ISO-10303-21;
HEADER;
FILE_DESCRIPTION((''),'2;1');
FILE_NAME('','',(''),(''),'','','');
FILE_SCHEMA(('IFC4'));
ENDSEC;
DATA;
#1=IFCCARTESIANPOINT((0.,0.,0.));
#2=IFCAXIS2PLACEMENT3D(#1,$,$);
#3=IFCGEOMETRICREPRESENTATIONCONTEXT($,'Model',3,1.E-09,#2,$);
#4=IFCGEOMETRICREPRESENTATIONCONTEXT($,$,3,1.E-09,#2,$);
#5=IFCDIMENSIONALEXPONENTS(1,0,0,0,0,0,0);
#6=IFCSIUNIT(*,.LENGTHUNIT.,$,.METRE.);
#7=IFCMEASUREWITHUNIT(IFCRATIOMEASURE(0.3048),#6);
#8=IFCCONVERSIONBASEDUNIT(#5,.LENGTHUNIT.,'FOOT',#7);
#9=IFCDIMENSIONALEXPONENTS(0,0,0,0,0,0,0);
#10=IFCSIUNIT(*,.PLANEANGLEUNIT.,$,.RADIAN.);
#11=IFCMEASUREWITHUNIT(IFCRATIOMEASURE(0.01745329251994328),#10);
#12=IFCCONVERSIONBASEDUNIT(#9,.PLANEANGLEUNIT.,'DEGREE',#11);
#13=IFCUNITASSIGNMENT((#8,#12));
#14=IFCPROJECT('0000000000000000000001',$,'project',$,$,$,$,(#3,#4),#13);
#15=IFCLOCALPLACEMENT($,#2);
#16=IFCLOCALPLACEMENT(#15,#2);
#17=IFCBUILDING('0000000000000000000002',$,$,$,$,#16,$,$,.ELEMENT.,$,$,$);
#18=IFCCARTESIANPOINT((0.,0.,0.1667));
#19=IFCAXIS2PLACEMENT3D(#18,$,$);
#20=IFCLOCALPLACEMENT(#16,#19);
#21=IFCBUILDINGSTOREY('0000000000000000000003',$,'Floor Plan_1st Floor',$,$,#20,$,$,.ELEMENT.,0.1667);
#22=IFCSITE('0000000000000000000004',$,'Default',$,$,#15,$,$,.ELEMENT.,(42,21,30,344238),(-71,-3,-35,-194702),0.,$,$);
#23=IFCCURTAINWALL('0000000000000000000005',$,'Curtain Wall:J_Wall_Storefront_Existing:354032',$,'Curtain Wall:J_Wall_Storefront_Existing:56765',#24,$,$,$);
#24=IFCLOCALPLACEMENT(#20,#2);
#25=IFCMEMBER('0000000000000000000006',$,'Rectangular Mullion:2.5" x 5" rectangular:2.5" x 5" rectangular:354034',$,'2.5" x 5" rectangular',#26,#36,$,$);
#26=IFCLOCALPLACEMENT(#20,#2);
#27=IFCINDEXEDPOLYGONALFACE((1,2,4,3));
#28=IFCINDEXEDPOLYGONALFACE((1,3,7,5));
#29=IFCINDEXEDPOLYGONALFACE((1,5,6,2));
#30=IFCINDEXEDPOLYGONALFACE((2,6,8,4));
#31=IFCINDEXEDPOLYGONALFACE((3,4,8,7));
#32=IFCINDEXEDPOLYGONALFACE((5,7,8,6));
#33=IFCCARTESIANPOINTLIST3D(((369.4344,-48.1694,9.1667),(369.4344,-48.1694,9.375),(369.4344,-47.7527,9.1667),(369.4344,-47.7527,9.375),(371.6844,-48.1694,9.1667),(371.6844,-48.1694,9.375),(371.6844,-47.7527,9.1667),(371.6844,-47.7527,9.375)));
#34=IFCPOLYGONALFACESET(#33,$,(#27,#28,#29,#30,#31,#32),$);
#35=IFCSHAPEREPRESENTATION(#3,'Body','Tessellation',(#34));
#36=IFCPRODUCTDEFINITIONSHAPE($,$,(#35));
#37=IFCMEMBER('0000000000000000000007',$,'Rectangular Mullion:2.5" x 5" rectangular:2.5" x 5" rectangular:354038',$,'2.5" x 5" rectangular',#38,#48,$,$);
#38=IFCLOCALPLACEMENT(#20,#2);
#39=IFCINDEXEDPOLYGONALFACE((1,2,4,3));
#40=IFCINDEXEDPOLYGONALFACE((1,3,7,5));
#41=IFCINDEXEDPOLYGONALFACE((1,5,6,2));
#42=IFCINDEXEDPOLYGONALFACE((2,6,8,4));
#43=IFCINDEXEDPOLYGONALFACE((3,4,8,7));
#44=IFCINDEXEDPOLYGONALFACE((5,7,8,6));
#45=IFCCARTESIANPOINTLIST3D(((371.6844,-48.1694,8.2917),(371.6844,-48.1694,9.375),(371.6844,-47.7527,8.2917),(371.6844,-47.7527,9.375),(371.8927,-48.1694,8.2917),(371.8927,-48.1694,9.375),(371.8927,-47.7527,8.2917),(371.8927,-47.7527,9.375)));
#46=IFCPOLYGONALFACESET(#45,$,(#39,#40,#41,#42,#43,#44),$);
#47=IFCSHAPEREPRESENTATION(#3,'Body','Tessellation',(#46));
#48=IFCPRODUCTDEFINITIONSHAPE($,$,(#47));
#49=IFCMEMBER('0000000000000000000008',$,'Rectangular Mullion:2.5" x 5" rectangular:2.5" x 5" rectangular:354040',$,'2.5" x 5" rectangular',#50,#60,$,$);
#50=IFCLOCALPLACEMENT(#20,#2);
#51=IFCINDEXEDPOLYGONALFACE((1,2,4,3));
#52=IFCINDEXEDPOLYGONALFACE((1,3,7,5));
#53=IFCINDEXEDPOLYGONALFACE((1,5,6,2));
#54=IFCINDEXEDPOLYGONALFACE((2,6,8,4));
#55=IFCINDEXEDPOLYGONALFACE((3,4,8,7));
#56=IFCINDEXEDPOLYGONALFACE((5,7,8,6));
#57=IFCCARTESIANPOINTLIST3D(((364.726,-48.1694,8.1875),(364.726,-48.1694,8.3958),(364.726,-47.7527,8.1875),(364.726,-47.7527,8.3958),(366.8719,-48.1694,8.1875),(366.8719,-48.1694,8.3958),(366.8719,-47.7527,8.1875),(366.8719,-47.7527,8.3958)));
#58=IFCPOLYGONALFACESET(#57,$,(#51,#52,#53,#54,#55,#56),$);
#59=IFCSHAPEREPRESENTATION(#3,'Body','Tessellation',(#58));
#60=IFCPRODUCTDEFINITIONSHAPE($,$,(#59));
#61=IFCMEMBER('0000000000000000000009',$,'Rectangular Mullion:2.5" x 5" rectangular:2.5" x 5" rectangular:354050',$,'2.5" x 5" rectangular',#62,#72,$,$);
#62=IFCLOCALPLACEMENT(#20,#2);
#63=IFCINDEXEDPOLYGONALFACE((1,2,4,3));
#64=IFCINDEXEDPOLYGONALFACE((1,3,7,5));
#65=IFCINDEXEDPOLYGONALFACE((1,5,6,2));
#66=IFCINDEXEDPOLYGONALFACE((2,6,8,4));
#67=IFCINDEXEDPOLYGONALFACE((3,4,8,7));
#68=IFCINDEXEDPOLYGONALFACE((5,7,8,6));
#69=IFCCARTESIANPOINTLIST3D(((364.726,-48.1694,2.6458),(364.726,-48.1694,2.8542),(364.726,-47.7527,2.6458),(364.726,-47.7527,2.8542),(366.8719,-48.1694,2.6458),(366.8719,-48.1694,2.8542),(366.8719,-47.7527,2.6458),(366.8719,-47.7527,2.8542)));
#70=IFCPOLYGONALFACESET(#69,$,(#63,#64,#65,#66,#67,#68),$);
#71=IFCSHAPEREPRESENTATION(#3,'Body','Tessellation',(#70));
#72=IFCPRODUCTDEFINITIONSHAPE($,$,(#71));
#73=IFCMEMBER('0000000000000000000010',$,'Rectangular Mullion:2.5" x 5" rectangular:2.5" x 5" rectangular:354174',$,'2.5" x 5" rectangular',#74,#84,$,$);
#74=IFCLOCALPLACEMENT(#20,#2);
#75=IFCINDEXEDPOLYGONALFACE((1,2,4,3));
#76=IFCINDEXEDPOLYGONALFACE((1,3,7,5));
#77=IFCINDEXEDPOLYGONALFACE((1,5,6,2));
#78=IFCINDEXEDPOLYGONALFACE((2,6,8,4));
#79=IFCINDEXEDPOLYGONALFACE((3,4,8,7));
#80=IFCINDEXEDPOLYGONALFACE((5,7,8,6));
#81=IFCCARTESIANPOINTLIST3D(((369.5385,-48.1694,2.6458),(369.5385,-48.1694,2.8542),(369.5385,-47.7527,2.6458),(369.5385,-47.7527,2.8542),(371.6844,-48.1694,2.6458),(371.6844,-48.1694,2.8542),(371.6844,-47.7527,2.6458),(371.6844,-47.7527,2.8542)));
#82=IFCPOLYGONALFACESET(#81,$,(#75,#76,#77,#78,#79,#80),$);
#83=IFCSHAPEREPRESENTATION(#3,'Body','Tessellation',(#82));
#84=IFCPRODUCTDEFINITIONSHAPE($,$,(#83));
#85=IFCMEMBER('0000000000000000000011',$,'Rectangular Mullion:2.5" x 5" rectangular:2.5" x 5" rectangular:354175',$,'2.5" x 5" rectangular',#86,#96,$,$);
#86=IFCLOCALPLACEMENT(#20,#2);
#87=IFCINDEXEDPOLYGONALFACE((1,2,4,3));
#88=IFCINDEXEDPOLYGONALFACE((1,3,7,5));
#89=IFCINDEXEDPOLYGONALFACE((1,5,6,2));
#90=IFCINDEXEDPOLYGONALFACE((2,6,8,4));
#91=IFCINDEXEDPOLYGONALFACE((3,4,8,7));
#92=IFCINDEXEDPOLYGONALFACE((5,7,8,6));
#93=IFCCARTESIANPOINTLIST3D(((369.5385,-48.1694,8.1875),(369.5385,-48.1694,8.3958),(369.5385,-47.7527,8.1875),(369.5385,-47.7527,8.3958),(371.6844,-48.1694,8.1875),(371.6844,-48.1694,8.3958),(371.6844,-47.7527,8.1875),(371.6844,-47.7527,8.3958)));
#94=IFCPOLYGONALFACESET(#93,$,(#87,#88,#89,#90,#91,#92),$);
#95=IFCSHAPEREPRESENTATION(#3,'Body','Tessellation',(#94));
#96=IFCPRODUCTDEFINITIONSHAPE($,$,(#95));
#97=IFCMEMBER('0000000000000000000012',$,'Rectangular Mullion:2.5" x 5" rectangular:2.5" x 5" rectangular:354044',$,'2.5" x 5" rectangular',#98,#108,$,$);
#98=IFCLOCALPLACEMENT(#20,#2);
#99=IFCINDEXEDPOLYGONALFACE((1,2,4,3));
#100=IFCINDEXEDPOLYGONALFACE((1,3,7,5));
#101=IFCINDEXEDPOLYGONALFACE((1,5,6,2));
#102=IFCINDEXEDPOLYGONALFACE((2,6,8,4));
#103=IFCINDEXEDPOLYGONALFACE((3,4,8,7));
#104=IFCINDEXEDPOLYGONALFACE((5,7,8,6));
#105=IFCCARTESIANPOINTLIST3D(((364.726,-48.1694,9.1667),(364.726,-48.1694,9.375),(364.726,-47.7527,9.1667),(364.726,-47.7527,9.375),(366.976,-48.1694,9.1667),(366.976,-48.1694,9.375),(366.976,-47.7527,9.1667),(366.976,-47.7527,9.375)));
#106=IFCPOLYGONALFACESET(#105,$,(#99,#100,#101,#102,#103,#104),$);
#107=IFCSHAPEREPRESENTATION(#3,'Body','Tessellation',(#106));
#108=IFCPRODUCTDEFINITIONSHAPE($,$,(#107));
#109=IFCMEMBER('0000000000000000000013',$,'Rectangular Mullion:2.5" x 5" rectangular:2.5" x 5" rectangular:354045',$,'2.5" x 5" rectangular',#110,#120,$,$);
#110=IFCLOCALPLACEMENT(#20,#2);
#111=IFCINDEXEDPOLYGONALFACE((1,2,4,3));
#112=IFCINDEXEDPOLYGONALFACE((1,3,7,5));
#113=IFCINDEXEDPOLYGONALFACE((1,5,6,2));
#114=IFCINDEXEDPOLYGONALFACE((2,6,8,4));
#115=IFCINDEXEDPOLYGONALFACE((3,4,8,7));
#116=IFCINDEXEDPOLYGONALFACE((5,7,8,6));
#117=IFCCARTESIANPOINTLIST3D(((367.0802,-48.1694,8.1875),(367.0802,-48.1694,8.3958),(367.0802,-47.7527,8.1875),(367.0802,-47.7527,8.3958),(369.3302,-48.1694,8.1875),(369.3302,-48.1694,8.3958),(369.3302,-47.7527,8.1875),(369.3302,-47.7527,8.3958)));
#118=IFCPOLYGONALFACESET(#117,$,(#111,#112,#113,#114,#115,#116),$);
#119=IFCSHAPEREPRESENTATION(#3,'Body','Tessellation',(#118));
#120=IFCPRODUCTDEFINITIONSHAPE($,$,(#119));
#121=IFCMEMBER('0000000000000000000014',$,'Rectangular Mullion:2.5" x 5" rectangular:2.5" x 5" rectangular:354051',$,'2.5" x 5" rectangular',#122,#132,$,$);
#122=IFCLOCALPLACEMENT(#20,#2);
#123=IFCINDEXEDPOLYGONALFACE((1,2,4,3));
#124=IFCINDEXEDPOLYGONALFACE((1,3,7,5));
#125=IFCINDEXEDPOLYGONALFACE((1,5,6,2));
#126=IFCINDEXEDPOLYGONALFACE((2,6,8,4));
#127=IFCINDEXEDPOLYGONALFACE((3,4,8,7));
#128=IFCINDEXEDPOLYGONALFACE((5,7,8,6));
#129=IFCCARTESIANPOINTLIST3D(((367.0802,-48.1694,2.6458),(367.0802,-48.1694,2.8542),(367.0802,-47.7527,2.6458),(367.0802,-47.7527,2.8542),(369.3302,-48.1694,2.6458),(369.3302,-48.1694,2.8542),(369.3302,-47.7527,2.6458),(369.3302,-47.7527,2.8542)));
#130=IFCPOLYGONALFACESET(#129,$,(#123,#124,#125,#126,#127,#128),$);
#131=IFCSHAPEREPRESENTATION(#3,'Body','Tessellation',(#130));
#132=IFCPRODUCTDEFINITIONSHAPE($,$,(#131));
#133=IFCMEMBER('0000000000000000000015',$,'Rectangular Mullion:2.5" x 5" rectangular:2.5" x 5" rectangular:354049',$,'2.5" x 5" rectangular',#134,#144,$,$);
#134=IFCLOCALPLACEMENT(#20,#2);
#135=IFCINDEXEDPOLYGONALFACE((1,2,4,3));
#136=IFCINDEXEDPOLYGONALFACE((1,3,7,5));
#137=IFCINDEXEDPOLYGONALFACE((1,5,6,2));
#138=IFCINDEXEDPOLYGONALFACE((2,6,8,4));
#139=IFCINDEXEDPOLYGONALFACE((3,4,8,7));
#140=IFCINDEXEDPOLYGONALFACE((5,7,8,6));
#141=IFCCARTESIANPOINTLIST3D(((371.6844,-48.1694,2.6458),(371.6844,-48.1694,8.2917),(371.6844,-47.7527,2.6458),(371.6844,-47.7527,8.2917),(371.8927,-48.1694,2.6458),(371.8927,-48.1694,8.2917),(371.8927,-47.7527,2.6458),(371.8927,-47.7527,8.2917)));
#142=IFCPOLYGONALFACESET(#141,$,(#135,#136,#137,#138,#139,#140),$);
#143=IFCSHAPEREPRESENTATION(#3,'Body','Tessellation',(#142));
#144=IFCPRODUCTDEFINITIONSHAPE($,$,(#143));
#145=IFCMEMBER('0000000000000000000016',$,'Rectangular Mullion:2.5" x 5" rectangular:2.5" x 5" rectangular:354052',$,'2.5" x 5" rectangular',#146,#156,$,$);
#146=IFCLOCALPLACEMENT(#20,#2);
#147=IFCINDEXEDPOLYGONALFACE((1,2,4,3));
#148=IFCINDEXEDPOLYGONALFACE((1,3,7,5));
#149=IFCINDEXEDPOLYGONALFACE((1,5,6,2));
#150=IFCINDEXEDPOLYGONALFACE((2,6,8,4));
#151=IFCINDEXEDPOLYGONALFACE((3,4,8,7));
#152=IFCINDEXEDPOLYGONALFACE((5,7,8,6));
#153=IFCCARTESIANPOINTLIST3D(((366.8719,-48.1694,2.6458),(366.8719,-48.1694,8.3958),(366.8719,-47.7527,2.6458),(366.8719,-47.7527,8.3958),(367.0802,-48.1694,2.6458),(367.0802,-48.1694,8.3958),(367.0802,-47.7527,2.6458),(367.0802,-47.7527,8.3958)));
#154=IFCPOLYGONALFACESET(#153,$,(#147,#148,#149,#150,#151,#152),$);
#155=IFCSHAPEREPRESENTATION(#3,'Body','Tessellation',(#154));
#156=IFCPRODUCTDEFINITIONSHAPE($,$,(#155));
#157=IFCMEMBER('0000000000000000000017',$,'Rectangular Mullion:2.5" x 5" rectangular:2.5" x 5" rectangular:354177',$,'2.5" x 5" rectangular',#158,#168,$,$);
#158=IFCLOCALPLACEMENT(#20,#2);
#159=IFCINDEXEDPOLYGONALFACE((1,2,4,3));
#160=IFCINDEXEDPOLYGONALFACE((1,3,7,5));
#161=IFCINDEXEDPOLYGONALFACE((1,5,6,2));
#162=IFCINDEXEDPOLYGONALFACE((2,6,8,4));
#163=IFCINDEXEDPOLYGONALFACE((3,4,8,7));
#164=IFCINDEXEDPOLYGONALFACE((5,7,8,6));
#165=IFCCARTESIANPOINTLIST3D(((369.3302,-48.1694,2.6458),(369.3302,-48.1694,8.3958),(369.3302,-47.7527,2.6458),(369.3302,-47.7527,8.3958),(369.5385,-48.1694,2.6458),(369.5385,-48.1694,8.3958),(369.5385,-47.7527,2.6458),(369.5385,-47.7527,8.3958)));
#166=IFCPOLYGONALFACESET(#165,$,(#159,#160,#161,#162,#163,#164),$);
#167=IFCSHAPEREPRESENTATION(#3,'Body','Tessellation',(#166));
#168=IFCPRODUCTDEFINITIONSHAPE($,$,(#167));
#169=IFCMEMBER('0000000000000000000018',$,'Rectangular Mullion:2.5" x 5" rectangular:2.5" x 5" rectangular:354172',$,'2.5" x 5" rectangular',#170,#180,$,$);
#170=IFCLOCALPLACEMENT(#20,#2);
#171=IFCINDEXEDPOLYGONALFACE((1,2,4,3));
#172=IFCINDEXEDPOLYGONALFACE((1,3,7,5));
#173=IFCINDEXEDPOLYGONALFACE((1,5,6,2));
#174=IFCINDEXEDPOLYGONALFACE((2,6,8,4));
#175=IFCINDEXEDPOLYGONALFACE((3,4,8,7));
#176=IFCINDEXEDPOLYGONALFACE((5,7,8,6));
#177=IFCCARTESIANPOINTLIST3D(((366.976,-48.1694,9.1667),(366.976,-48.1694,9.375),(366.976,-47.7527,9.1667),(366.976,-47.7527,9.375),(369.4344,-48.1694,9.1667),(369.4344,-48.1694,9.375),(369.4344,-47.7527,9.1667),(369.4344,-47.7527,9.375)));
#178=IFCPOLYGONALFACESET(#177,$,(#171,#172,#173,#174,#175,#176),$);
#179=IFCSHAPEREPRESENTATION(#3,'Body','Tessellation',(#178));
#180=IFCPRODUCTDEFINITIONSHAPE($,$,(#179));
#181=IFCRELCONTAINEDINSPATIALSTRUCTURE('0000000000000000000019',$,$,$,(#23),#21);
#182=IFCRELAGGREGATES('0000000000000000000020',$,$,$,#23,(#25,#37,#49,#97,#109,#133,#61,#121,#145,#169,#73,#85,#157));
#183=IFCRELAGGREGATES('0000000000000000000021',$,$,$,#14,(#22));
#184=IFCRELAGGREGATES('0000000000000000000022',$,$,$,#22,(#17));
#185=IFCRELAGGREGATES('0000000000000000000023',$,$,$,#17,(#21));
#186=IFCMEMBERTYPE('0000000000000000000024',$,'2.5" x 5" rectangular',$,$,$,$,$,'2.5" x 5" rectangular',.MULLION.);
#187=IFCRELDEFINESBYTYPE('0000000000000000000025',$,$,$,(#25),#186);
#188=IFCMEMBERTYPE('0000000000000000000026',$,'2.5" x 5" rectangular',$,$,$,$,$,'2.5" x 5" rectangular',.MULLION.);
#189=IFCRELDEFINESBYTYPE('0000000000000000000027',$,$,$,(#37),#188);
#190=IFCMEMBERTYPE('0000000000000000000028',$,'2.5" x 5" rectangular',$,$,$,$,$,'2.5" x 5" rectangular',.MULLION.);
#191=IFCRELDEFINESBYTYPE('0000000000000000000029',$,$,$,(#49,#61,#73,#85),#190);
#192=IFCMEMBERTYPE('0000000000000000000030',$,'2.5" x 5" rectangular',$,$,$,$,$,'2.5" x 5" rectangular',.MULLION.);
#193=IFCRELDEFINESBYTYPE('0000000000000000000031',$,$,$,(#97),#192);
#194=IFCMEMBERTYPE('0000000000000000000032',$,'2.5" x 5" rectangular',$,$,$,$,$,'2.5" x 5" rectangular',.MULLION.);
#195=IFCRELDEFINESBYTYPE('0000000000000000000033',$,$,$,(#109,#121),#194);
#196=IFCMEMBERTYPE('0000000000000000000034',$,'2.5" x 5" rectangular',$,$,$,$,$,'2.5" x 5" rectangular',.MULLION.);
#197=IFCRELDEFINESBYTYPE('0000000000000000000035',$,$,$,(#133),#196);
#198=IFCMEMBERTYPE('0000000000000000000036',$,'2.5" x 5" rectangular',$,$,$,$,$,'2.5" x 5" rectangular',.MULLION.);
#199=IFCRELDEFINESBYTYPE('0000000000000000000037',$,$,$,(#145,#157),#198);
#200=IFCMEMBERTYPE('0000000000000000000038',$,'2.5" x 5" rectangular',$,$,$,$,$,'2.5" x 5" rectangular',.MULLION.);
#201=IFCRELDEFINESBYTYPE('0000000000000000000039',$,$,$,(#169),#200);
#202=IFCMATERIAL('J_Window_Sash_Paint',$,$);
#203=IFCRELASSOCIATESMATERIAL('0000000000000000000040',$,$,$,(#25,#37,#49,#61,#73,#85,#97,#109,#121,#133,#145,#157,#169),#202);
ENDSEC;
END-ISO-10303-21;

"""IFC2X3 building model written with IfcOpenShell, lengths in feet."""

from ifc_helpers import new_model, entity, si_unit, converted_unit, frame, origin, origin_2d_with_axis, place, context, project, spatial, rectangle, extrude, source, transform, mapped, material, type_object, type_shapes, element, aggregate, save


model = new_model("IFC2X3")

# Units and contexts
model_context = context("Model", 3, precision=1e-09, world=origin())
context_of_model = context(None, 3, precision=1e-09, world=origin())
ifc_project = project(units=[converted_unit("LENGTHUNIT", "FOOT", entity("IfcRatioMeasure", 0.3048), si_unit("LENGTHUNIT", "METRE"), dimensions=[1, 0, 0, 0, 0, 0, 0]), converted_unit("PLANEANGLEUNIT", "DEGREE", entity("IfcRatioMeasure", 0.01745329251994328), si_unit("PLANEANGLEUNIT", "RADIAN"), dimensions=[0, 0, 0, 0, 0, 0, 0])], contexts=[model_context, context_of_model])

# Site, building, storey
site_placement = place(None, origin())
site = spatial("IfcSite", under=ifc_project, at=site_placement, Name="Default", CompositionType="ELEMENT", RefLatitude=(42, 21, 30, 344238), RefLongitude=(-71, -3, -35, -194702), RefElevation=0.0)
building_placement = place(site_placement, origin())
building = spatial("IfcBuilding", under=site, at=building_placement, CompositionType="ELEMENT")
storey_placement = place(building_placement, frame((0.0, 0.0, 0.1667)))
storey = spatial("IfcBuildingStorey", under=building, at=storey_placement, Name="Floor Plan_1st Floor", CompositionType="ELEMENT", Elevation=0.1667)

# Curtain wall, members
curtain_wall_1_placement = place(storey_placement, origin())
curtain_wall_1 = element("IfcCurtainWall", 1, at=curtain_wall_1_placement, inside=storey, Name="Curtain Wall:J_Wall_Storefront_Existing:354032", ObjectType="Curtain Wall:J_Wall_Storefront_Existing:56765")
ifc_material_1 = material(Name="J_Window_Sash_Paint")
member_type_1 = type_object("IfcMemberType", Name="2.5\" x 5\" rectangular", ElementType="2.5\" x 5\" rectangular", PredefinedType="MULLION")
shared_shape_1 = source(origin(), model_context, "Body", "SweptSolid", [
    extrude(rectangle(XDim=0.2083, YDim=0.4167, at=origin_2d_with_axis()), frame((-0.1042, 0.0, -2.25), z_axis=(0.0, 0.0, 1.0), x_axis=(-1.0, 0.0, 0.0)), (0.0, 0.0, 1.0), 2.25),
])
type_shapes(member_type_1, [shared_shape_1])
member_1_placement = place(storey_placement, frame((371.6844, -47.9611, 9.375), z_axis=(1.0, 0.0, 0.0), x_axis=(0.0, 0.0, 1.0)))
member_1 = element("IfcMember", 2, at=member_1_placement, type_object=member_type_1, material=ifc_material_1, Name="Rectangular Mullion:2.5\" x 5\" rectangular:2.5\" x 5\" rectangular:354034", ObjectType="2.5\" x 5\" rectangular", context=model_context, shape_type="MappedRepresentation", body=[
    mapped(shared_shape_1, transform((0.0, 0.0, 0.0), scale=1.0)),
])
member_type_2 = type_object("IfcMemberType", Name="2.5\" x 5\" rectangular", ElementType="2.5\" x 5\" rectangular", PredefinedType="MULLION")
shared_shape_2 = source(origin(), model_context, "Body", "SweptSolid", [
    extrude(rectangle(XDim=0.2083, YDim=0.4167, at=origin_2d_with_axis()), frame((-0.1042, 0.0, -1.0833), z_axis=(0.0, 0.0, 1.0), x_axis=(-1.0, 0.0, 0.0)), (0.0, 0.0, 1.0), 1.0833),
])
type_shapes(member_type_2, [shared_shape_2])
member_2_placement = place(storey_placement, frame((371.8927, -47.9611, 8.2917), z_axis=(0.0, 0.0, -1.0), x_axis=(1.0, 0.0, 0.0)))
member_2 = element("IfcMember", 3, at=member_2_placement, type_object=member_type_2, material=ifc_material_1, Name="Rectangular Mullion:2.5\" x 5\" rectangular:2.5\" x 5\" rectangular:354038", ObjectType="2.5\" x 5\" rectangular", context=model_context, shape_type="MappedRepresentation", body=[
    mapped(shared_shape_2, transform((0.0, 0.0, 0.0), scale=1.0)),
])
member_type_3 = type_object("IfcMemberType", Name="2.5\" x 5\" rectangular", ElementType="2.5\" x 5\" rectangular", PredefinedType="MULLION")
shared_shape_3 = source(origin(), model_context, "Body", "SweptSolid", [
    extrude(rectangle(XDim=0.2083, YDim=0.4167, at=origin_2d_with_axis()), frame((0.0, 0.0, -2.1458), z_axis=(0.0, 0.0, 1.0), x_axis=(-1.0, 0.0, 0.0)), (0.0, 0.0, 1.0), 2.1458),
])
type_shapes(member_type_3, [shared_shape_3])
member_3_placement = place(storey_placement, frame((366.8719, -47.9611, 8.2917), z_axis=(1.0, 0.0, 0.0), x_axis=(0.0, 0.0, 1.0)))
member_3 = element("IfcMember", 4, at=member_3_placement, type_object=member_type_3, material=ifc_material_1, Name="Rectangular Mullion:2.5\" x 5\" rectangular:2.5\" x 5\" rectangular:354040", ObjectType="2.5\" x 5\" rectangular", context=model_context, shape_type="MappedRepresentation", body=[
    mapped(shared_shape_3, transform((0.0, 0.0, 0.0), scale=1.0)),
])
member_4_placement = place(storey_placement, frame((366.8719, -47.9611, 2.75), z_axis=(1.0, 0.0, 0.0), x_axis=(0.0, 0.0, 1.0)))
member_4 = element("IfcMember", 5, at=member_4_placement, type_object=member_type_3, material=ifc_material_1, Name="Rectangular Mullion:2.5\" x 5\" rectangular:2.5\" x 5\" rectangular:354050", ObjectType="2.5\" x 5\" rectangular", context=model_context, shape_type="MappedRepresentation", body=[
    mapped(shared_shape_3, transform((0.0, 0.0, 0.0), scale=1.0)),
])
member_5_placement = place(storey_placement, frame((371.6844, -47.9611, 2.75), z_axis=(1.0, 0.0, 0.0), x_axis=(0.0, 0.0, 1.0)))
member_5 = element("IfcMember", 6, at=member_5_placement, type_object=member_type_3, material=ifc_material_1, Name="Rectangular Mullion:2.5\" x 5\" rectangular:2.5\" x 5\" rectangular:354174", ObjectType="2.5\" x 5\" rectangular", context=model_context, shape_type="MappedRepresentation", body=[
    mapped(shared_shape_3, transform((0.0, 0.0, 0.0), scale=1.0)),
])
member_6_placement = place(storey_placement, frame((371.6844, -47.9611, 8.2917), z_axis=(1.0, 0.0, 0.0), x_axis=(0.0, 0.0, 1.0)))
member_6 = element("IfcMember", 7, at=member_6_placement, type_object=member_type_3, material=ifc_material_1, Name="Rectangular Mullion:2.5\" x 5\" rectangular:2.5\" x 5\" rectangular:354175", ObjectType="2.5\" x 5\" rectangular", context=model_context, shape_type="MappedRepresentation", body=[
    mapped(shared_shape_3, transform((0.0, 0.0, 0.0), scale=1.0)),
])
member_type_4 = type_object("IfcMemberType", Name="2.5\" x 5\" rectangular", ElementType="2.5\" x 5\" rectangular", PredefinedType="MULLION")
shared_shape_4 = source(origin(), model_context, "Body", "SweptSolid", [
    extrude(rectangle(XDim=0.2083, YDim=0.4167, at=origin_2d_with_axis()), frame((-0.1042, 0.0, -2.25), z_axis=(0.0, 0.0, 1.0), x_axis=(-1.0, 0.0, 0.0)), (0.0, 0.0, 1.0), 2.25),
])
type_shapes(member_type_4, [shared_shape_4])
member_7_placement = place(storey_placement, frame((366.976, -47.9611, 9.375), z_axis=(1.0, 0.0, 0.0), x_axis=(0.0, 0.0, 1.0)))
member_7 = element("IfcMember", 8, at=member_7_placement, type_object=member_type_4, material=ifc_material_1, Name="Rectangular Mullion:2.5\" x 5\" rectangular:2.5\" x 5\" rectangular:354044", ObjectType="2.5\" x 5\" rectangular", context=model_context, shape_type="MappedRepresentation", body=[
    mapped(shared_shape_4, transform((0.0, 0.0, 0.0), scale=1.0)),
])
member_type_5 = type_object("IfcMemberType", Name="2.5\" x 5\" rectangular", ElementType="2.5\" x 5\" rectangular", PredefinedType="MULLION")
shared_shape_5 = source(origin(), model_context, "Body", "SweptSolid", [
    extrude(rectangle(XDim=0.2083, YDim=0.4167, at=origin_2d_with_axis()), frame((0.0, 0.0, -2.25), z_axis=(0.0, 0.0, 1.0), x_axis=(-1.0, 0.0, 0.0)), (0.0, 0.0, 1.0), 2.25),
])
type_shapes(member_type_5, [shared_shape_5])
member_8_placement = place(storey_placement, frame((369.3302, -47.9611, 8.2917), z_axis=(1.0, 0.0, 0.0), x_axis=(0.0, 0.0, 1.0)))
member_8 = element("IfcMember", 9, at=member_8_placement, type_object=member_type_5, material=ifc_material_1, Name="Rectangular Mullion:2.5\" x 5\" rectangular:2.5\" x 5\" rectangular:354045", ObjectType="2.5\" x 5\" rectangular", context=model_context, shape_type="MappedRepresentation", body=[
    mapped(shared_shape_5, transform((0.0, 0.0, 0.0), scale=1.0)),
])
member_9_placement = place(storey_placement, frame((369.3302, -47.9611, 2.75), z_axis=(1.0, 0.0, 0.0), x_axis=(0.0, 0.0, 1.0)))
member_9 = element("IfcMember", 10, at=member_9_placement, type_object=member_type_5, material=ifc_material_1, Name="Rectangular Mullion:2.5\" x 5\" rectangular:2.5\" x 5\" rectangular:354051", ObjectType="2.5\" x 5\" rectangular", context=model_context, shape_type="MappedRepresentation", body=[
    mapped(shared_shape_5, transform((0.0, 0.0, 0.0), scale=1.0)),
])
member_type_6 = type_object("IfcMemberType", Name="2.5\" x 5\" rectangular", ElementType="2.5\" x 5\" rectangular", PredefinedType="MULLION")
shared_shape_6 = source(origin(), model_context, "Body", "SweptSolid", [
    extrude(rectangle(XDim=0.2083, YDim=0.4167, at=origin_2d_with_axis()), frame((-0.1042, 0.0, -5.6458), z_axis=(0.0, 0.0, 1.0), x_axis=(-1.0, 0.0, 0.0)), (0.0, 0.0, 1.0), 5.6458),
])
type_shapes(member_type_6, [shared_shape_6])
member_10_placement = place(storey_placement, frame((371.8927, -47.9611, 2.6458), z_axis=(0.0, 0.0, -1.0), x_axis=(1.0, 0.0, 0.0)))
member_10 = element("IfcMember", 11, at=member_10_placement, type_object=member_type_6, material=ifc_material_1, Name="Rectangular Mullion:2.5\" x 5\" rectangular:2.5\" x 5\" rectangular:354049", ObjectType="2.5\" x 5\" rectangular", context=model_context, shape_type="MappedRepresentation", body=[
    mapped(shared_shape_6, transform((0.0, 0.0, 0.0), scale=1.0)),
])
member_type_7 = type_object("IfcMemberType", Name="2.5\" x 5\" rectangular", ElementType="2.5\" x 5\" rectangular", PredefinedType="MULLION")
shared_shape_7 = source(origin(), model_context, "Body", "SweptSolid", [
    extrude(rectangle(XDim=0.2083, YDim=0.4167, at=origin_2d_with_axis()), frame((0.0, 0.0, -5.75), z_axis=(0.0, 0.0, 1.0), x_axis=(-1.0, 0.0, 0.0)), (0.0, 0.0, 1.0), 5.75),
])
type_shapes(member_type_7, [shared_shape_7])
member_11_placement = place(storey_placement, frame((366.976, -47.9611, 2.6458), z_axis=(0.0, 0.0, -1.0), x_axis=(1.0, 0.0, 0.0)))
member_11 = element("IfcMember", 12, at=member_11_placement, type_object=member_type_7, material=ifc_material_1, Name="Rectangular Mullion:2.5\" x 5\" rectangular:2.5\" x 5\" rectangular:354052", ObjectType="2.5\" x 5\" rectangular", context=model_context, shape_type="MappedRepresentation", body=[
    mapped(shared_shape_7, transform((0.0, 0.0, 0.0), scale=1.0)),
])
member_12_placement = place(storey_placement, frame((369.4344, -47.9611, 2.6458), z_axis=(0.0, 0.0, -1.0), x_axis=(1.0, 0.0, 0.0)))
member_12 = element("IfcMember", 13, at=member_12_placement, type_object=member_type_7, material=ifc_material_1, Name="Rectangular Mullion:2.5\" x 5\" rectangular:2.5\" x 5\" rectangular:354177", ObjectType="2.5\" x 5\" rectangular", context=model_context, shape_type="MappedRepresentation", body=[
    mapped(shared_shape_7, transform((0.0, 0.0, 0.0), scale=1.0)),
])
member_type_8 = type_object("IfcMemberType", Name="2.5\" x 5\" rectangular", ElementType="2.5\" x 5\" rectangular", PredefinedType="MULLION")
shared_shape_8 = source(origin(), model_context, "Body", "SweptSolid", [
    extrude(rectangle(XDim=0.2083, YDim=0.4167, at=origin_2d_with_axis()), frame((-0.1042, 0.0, -2.4583), z_axis=(0.0, 0.0, 1.0), x_axis=(-1.0, 0.0, 0.0)), (0.0, 0.0, 1.0), 2.4583),
])
type_shapes(member_type_8, [shared_shape_8])
member_13_placement = place(storey_placement, frame((369.4344, -47.9611, 9.375), z_axis=(1.0, 0.0, 0.0), x_axis=(0.0, 0.0, 1.0)))
member_13 = element("IfcMember", 14, at=member_13_placement, type_object=member_type_8, material=ifc_material_1, Name="Rectangular Mullion:2.5\" x 5\" rectangular:2.5\" x 5\" rectangular:354172", ObjectType="2.5\" x 5\" rectangular", context=model_context, shape_type="MappedRepresentation", body=[
    mapped(shared_shape_8, transform((0.0, 0.0, 0.0), scale=1.0)),
])

aggregate(curtain_wall_1, [member_1, member_2, member_3, member_7, member_8, member_10, member_4, member_9, member_11, member_13, member_5, member_6, member_12])

save(model, "model.ifc")
